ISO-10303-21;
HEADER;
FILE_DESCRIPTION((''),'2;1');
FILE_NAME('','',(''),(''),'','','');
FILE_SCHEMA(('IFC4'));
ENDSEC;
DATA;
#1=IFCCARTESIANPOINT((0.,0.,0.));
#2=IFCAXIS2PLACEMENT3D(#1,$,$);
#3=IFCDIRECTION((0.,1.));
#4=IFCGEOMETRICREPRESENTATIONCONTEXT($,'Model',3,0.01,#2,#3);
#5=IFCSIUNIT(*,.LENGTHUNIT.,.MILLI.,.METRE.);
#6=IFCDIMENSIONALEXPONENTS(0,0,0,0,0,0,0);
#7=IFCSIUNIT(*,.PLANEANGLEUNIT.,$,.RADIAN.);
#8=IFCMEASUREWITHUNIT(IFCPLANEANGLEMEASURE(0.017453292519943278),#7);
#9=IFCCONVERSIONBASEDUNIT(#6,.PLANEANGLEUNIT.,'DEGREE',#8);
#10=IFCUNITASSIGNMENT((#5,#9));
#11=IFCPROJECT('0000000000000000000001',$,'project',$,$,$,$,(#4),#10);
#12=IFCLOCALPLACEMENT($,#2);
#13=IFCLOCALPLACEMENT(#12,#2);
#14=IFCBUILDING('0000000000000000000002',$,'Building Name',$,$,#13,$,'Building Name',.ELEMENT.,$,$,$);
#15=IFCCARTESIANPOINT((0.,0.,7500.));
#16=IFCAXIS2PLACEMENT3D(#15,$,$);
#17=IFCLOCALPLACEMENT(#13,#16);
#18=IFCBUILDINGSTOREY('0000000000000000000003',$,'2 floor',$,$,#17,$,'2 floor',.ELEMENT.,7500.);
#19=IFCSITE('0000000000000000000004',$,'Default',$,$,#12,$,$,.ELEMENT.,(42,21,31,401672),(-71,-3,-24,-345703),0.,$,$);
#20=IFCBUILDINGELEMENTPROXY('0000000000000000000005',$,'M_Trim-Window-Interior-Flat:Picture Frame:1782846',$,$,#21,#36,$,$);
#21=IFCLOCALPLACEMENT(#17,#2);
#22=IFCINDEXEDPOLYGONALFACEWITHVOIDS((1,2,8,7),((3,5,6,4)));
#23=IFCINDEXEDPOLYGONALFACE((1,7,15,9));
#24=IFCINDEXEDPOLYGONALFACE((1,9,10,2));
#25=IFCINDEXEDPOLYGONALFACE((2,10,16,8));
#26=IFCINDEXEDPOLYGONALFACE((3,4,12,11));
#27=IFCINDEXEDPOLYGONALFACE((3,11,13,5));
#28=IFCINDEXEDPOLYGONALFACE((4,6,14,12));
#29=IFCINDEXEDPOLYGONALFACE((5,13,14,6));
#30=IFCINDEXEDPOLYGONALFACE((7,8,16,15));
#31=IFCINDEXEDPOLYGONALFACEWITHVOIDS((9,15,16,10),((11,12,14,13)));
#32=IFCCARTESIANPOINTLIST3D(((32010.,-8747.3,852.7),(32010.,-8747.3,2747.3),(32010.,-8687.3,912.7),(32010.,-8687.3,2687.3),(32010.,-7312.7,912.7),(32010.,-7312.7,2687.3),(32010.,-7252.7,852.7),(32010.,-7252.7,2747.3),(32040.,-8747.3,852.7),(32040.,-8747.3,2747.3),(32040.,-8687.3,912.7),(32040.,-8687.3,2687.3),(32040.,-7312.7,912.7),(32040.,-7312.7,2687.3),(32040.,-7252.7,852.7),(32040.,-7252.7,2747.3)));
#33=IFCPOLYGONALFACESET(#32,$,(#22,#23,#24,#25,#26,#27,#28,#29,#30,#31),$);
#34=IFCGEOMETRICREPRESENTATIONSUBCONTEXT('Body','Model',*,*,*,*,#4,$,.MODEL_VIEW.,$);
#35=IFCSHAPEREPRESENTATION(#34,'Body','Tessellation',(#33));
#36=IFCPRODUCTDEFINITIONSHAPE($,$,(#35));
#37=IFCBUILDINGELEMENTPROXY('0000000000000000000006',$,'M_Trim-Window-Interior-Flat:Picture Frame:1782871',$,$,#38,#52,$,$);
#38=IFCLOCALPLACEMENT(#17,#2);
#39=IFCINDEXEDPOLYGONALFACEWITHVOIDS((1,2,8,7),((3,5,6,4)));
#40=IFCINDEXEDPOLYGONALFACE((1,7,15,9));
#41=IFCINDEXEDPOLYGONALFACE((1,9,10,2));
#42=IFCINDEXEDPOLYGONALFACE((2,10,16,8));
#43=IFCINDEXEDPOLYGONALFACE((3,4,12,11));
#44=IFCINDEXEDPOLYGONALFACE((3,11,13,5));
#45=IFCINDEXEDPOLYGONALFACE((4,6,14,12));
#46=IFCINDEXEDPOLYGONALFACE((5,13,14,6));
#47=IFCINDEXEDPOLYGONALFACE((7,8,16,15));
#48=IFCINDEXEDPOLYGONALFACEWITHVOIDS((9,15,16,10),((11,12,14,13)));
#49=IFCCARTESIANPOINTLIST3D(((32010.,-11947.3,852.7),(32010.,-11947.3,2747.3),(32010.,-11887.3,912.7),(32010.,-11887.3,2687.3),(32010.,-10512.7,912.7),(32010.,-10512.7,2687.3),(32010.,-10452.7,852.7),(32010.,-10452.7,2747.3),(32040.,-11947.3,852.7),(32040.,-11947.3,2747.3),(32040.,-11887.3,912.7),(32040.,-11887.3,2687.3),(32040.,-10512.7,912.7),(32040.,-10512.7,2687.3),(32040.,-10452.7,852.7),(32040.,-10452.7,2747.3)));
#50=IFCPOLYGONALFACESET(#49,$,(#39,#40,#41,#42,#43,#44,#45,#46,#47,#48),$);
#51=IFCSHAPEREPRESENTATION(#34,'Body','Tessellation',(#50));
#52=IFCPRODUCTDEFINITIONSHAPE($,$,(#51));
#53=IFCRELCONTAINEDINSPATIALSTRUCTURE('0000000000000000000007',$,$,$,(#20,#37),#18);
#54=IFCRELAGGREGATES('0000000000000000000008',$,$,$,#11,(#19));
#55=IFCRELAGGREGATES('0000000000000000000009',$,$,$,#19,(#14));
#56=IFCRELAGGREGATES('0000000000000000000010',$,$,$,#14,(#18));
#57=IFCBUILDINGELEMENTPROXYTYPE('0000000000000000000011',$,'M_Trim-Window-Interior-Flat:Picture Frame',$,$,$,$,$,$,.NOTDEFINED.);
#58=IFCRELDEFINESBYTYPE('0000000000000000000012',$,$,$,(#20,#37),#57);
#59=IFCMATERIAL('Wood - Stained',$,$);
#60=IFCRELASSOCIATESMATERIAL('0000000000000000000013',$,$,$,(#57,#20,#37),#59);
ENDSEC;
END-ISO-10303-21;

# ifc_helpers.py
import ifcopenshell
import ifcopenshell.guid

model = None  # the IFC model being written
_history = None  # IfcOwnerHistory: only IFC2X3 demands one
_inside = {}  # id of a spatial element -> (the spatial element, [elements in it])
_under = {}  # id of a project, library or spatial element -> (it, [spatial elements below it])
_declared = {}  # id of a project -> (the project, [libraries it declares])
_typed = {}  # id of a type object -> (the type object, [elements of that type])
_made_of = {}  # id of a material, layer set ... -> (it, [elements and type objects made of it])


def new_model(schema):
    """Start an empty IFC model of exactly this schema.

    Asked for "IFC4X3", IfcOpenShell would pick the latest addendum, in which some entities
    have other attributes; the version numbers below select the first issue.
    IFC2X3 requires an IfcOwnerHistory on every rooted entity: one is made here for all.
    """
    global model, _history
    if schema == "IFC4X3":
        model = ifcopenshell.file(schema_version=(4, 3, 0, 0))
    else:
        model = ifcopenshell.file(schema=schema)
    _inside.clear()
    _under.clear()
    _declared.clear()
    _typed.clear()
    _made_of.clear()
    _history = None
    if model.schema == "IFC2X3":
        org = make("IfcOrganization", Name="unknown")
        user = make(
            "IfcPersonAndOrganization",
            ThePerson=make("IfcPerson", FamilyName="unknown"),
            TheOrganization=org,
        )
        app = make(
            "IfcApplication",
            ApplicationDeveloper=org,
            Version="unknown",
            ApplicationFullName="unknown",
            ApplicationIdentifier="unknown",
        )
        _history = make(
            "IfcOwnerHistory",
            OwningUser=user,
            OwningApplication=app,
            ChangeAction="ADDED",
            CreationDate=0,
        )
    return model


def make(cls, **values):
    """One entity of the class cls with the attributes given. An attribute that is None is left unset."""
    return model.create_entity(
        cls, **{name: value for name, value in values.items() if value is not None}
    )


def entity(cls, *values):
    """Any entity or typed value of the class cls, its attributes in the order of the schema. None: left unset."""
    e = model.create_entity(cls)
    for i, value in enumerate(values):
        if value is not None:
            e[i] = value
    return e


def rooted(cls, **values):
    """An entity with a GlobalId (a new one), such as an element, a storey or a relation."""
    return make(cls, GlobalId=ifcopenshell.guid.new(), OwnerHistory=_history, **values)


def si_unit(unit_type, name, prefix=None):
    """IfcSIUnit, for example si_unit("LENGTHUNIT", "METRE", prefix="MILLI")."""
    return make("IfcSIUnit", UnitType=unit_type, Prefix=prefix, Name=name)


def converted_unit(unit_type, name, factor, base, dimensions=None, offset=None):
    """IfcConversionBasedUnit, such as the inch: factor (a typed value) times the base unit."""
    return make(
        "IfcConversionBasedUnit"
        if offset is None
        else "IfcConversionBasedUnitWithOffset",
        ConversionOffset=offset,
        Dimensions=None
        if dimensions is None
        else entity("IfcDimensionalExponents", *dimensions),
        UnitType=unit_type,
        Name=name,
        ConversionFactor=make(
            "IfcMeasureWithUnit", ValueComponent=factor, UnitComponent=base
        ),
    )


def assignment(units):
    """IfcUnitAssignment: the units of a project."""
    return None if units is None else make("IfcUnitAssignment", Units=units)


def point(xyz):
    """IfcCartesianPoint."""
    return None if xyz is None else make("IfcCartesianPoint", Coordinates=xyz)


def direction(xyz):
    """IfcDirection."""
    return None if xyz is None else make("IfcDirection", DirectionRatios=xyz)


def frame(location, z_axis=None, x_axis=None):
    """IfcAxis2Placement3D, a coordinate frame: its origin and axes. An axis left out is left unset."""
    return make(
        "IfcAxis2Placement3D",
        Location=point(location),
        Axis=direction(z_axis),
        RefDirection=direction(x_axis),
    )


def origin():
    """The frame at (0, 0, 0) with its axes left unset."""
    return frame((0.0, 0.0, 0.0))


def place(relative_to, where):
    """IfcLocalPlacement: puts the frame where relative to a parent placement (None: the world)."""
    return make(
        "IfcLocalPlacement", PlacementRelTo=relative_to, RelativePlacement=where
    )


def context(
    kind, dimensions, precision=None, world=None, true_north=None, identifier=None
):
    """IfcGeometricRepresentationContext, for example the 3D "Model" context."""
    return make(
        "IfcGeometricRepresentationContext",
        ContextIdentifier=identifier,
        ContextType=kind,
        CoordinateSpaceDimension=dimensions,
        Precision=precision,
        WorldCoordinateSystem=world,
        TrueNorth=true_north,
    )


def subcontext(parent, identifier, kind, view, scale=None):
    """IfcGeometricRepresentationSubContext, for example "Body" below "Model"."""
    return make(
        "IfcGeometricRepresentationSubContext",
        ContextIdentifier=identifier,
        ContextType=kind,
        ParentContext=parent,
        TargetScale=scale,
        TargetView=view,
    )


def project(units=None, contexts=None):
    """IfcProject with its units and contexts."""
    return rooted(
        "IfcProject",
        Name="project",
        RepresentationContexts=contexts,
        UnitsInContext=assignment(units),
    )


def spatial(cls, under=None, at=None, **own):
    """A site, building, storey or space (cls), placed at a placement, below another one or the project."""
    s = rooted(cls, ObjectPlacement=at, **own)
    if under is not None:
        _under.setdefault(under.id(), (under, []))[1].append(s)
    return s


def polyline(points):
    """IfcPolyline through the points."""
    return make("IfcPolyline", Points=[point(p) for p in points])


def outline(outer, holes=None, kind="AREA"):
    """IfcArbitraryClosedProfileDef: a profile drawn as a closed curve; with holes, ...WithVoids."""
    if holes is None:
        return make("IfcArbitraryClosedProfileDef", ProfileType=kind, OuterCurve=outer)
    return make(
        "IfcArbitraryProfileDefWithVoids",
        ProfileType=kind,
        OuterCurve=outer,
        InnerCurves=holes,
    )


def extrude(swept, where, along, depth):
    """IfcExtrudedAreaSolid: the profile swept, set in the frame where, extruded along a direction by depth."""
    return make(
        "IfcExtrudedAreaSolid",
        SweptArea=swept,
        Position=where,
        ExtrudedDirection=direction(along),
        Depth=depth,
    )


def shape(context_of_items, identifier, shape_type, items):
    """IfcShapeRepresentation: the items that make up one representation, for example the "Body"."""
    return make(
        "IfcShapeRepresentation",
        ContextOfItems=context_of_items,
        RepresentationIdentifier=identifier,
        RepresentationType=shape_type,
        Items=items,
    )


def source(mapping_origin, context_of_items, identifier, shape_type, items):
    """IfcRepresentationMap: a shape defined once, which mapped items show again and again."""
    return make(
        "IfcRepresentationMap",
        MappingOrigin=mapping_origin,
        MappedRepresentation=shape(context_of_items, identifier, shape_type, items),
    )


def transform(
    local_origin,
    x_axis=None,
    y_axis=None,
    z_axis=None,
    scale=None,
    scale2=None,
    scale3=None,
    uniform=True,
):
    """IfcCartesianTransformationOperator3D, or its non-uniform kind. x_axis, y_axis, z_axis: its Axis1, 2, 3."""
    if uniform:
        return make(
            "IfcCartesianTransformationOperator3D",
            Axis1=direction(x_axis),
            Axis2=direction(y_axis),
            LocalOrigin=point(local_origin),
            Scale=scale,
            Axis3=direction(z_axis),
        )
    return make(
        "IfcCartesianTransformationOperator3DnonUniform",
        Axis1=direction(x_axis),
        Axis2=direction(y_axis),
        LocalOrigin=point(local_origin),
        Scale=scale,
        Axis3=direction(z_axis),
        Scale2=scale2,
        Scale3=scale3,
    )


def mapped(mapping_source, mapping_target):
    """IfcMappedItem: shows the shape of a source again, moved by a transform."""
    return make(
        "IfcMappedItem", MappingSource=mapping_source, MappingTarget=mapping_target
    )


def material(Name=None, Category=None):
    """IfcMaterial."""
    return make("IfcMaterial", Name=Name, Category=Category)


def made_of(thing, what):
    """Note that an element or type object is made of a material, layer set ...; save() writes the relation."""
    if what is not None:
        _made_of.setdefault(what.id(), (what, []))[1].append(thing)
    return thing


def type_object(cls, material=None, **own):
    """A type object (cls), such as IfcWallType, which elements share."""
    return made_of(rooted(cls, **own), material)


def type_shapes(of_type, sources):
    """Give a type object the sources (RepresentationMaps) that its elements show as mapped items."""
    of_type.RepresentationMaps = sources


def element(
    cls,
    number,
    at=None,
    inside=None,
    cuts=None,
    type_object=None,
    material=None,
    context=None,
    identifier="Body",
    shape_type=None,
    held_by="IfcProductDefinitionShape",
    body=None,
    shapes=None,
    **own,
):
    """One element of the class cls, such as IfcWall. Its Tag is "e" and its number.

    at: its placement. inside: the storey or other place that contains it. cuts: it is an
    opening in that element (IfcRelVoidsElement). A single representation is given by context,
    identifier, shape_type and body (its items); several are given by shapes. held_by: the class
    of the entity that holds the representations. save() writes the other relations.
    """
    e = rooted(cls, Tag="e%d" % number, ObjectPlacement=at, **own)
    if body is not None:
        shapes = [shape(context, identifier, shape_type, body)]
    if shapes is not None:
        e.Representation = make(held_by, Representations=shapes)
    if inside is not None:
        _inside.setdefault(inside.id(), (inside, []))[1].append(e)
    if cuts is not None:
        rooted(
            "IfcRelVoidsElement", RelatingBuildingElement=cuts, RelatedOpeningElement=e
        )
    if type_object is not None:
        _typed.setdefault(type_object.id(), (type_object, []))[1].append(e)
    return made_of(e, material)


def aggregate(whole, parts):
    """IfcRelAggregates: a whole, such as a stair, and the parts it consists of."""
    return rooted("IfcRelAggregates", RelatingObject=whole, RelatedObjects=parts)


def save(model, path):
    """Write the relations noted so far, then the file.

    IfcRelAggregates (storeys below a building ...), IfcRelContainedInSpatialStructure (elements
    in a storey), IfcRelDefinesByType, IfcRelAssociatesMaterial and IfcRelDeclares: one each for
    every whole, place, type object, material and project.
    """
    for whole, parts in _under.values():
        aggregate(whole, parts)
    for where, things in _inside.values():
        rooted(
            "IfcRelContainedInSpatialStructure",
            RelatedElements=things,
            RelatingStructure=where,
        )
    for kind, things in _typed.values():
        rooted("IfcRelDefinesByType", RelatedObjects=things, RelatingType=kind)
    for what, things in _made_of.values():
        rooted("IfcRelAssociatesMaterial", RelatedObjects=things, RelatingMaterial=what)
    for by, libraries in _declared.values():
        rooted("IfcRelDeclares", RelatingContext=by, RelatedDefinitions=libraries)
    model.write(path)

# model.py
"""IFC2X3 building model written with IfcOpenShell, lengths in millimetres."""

from ifc_helpers import new_model, entity, si_unit, converted_unit, direction, frame, origin, place, context, subcontext, project, spatial, polyline, outline, extrude, source, transform, mapped, material, type_object, type_shapes, element, save


model = new_model("IFC2X3")

# Units and contexts
model_context = context("Model", 3, precision=0.01, world=origin(), true_north=direction((0.0, 1.0)))
body_context = subcontext(model_context, "Body", "Model", "MODEL_VIEW")
ifc_project = project(units=[si_unit("LENGTHUNIT", "METRE", prefix="MILLI"), converted_unit("PLANEANGLEUNIT", "DEGREE", entity("IfcPlaneAngleMeasure", 0.017453292519943278), si_unit("PLANEANGLEUNIT", "RADIAN"), dimensions=[0, 0, 0, 0, 0, 0, 0])], contexts=[model_context])

# Site, building, storey
site_placement = place(None, origin())
site = spatial("IfcSite", under=ifc_project, at=site_placement, Name="Default", CompositionType="ELEMENT", RefLatitude=(42, 21, 31, 401672), RefLongitude=(-71, -3, -24, -345703), RefElevation=0.0)
building_placement = place(site_placement, origin())
building = spatial("IfcBuilding", under=site, at=building_placement, Name="Building Name", LongName="Building Name", CompositionType="ELEMENT")
storey_placement = place(building_placement, frame((0.0, 0.0, 7500.0)))
storey = spatial("IfcBuildingStorey", under=building, at=storey_placement, Name="2 floor", LongName="2 floor", CompositionType="ELEMENT", Elevation=7500.0)

# Building element proxies
ifc_material_1 = material(Name="Wood - Stained")
building_element_proxy_type_1 = type_object("IfcBuildingElementProxyType", Name="M_Trim-Window-Interior-Flat:Picture Frame", PredefinedType="NOTDEFINED", material=ifc_material_1)
shared_shape_1 = source(origin(), body_context, "Body", "SweptSolid", [
    extrude(outline(polyline([(-747.3, -947.3), (747.3, -947.3), (747.3, 947.3), (-747.3, 947.3), (-747.3, -947.3)]), holes=[polyline([(-687.3, -887.3), (-687.3, 887.3), (687.3, 887.3), (687.3, -887.3), (-687.3, -887.3)])]), frame((0.0, -900.0, 0.0), z_axis=(0.0, 0.0, 1.0), x_axis=(-1.0, 0.0, 0.0)), (0.0, 0.0, 1.0), 30.0),
])
type_shapes(building_element_proxy_type_1, [shared_shape_1])
for number, where, z_axis, x_axis, name in (
    (1, (32040.0, -8000.0, 2700.0), (-1.0, 0.0, 0.0), (0.0, -1.0, 0.0), "M_Trim-Window-Interior-Flat:Picture Frame:1782846"),
    (2, (32040.0, -11200.0, 2700.0), (-1.0, 0.0, 0.0), (0.0, -1.0, 0.0), "M_Trim-Window-Interior-Flat:Picture Frame:1782871"),
):
    element("IfcBuildingElementProxy", number, at=place(storey_placement, frame(where, z_axis=z_axis, x_axis=x_axis)), inside=storey, type_object=building_element_proxy_type_1, material=ifc_material_1, Name=name, context=body_context, shape_type="MappedRepresentation", body=[
        mapped(shared_shape_1, transform((0.0, 0.0, 0.0), scale=1.0)),
    ])

save(model, "model.ifc")
